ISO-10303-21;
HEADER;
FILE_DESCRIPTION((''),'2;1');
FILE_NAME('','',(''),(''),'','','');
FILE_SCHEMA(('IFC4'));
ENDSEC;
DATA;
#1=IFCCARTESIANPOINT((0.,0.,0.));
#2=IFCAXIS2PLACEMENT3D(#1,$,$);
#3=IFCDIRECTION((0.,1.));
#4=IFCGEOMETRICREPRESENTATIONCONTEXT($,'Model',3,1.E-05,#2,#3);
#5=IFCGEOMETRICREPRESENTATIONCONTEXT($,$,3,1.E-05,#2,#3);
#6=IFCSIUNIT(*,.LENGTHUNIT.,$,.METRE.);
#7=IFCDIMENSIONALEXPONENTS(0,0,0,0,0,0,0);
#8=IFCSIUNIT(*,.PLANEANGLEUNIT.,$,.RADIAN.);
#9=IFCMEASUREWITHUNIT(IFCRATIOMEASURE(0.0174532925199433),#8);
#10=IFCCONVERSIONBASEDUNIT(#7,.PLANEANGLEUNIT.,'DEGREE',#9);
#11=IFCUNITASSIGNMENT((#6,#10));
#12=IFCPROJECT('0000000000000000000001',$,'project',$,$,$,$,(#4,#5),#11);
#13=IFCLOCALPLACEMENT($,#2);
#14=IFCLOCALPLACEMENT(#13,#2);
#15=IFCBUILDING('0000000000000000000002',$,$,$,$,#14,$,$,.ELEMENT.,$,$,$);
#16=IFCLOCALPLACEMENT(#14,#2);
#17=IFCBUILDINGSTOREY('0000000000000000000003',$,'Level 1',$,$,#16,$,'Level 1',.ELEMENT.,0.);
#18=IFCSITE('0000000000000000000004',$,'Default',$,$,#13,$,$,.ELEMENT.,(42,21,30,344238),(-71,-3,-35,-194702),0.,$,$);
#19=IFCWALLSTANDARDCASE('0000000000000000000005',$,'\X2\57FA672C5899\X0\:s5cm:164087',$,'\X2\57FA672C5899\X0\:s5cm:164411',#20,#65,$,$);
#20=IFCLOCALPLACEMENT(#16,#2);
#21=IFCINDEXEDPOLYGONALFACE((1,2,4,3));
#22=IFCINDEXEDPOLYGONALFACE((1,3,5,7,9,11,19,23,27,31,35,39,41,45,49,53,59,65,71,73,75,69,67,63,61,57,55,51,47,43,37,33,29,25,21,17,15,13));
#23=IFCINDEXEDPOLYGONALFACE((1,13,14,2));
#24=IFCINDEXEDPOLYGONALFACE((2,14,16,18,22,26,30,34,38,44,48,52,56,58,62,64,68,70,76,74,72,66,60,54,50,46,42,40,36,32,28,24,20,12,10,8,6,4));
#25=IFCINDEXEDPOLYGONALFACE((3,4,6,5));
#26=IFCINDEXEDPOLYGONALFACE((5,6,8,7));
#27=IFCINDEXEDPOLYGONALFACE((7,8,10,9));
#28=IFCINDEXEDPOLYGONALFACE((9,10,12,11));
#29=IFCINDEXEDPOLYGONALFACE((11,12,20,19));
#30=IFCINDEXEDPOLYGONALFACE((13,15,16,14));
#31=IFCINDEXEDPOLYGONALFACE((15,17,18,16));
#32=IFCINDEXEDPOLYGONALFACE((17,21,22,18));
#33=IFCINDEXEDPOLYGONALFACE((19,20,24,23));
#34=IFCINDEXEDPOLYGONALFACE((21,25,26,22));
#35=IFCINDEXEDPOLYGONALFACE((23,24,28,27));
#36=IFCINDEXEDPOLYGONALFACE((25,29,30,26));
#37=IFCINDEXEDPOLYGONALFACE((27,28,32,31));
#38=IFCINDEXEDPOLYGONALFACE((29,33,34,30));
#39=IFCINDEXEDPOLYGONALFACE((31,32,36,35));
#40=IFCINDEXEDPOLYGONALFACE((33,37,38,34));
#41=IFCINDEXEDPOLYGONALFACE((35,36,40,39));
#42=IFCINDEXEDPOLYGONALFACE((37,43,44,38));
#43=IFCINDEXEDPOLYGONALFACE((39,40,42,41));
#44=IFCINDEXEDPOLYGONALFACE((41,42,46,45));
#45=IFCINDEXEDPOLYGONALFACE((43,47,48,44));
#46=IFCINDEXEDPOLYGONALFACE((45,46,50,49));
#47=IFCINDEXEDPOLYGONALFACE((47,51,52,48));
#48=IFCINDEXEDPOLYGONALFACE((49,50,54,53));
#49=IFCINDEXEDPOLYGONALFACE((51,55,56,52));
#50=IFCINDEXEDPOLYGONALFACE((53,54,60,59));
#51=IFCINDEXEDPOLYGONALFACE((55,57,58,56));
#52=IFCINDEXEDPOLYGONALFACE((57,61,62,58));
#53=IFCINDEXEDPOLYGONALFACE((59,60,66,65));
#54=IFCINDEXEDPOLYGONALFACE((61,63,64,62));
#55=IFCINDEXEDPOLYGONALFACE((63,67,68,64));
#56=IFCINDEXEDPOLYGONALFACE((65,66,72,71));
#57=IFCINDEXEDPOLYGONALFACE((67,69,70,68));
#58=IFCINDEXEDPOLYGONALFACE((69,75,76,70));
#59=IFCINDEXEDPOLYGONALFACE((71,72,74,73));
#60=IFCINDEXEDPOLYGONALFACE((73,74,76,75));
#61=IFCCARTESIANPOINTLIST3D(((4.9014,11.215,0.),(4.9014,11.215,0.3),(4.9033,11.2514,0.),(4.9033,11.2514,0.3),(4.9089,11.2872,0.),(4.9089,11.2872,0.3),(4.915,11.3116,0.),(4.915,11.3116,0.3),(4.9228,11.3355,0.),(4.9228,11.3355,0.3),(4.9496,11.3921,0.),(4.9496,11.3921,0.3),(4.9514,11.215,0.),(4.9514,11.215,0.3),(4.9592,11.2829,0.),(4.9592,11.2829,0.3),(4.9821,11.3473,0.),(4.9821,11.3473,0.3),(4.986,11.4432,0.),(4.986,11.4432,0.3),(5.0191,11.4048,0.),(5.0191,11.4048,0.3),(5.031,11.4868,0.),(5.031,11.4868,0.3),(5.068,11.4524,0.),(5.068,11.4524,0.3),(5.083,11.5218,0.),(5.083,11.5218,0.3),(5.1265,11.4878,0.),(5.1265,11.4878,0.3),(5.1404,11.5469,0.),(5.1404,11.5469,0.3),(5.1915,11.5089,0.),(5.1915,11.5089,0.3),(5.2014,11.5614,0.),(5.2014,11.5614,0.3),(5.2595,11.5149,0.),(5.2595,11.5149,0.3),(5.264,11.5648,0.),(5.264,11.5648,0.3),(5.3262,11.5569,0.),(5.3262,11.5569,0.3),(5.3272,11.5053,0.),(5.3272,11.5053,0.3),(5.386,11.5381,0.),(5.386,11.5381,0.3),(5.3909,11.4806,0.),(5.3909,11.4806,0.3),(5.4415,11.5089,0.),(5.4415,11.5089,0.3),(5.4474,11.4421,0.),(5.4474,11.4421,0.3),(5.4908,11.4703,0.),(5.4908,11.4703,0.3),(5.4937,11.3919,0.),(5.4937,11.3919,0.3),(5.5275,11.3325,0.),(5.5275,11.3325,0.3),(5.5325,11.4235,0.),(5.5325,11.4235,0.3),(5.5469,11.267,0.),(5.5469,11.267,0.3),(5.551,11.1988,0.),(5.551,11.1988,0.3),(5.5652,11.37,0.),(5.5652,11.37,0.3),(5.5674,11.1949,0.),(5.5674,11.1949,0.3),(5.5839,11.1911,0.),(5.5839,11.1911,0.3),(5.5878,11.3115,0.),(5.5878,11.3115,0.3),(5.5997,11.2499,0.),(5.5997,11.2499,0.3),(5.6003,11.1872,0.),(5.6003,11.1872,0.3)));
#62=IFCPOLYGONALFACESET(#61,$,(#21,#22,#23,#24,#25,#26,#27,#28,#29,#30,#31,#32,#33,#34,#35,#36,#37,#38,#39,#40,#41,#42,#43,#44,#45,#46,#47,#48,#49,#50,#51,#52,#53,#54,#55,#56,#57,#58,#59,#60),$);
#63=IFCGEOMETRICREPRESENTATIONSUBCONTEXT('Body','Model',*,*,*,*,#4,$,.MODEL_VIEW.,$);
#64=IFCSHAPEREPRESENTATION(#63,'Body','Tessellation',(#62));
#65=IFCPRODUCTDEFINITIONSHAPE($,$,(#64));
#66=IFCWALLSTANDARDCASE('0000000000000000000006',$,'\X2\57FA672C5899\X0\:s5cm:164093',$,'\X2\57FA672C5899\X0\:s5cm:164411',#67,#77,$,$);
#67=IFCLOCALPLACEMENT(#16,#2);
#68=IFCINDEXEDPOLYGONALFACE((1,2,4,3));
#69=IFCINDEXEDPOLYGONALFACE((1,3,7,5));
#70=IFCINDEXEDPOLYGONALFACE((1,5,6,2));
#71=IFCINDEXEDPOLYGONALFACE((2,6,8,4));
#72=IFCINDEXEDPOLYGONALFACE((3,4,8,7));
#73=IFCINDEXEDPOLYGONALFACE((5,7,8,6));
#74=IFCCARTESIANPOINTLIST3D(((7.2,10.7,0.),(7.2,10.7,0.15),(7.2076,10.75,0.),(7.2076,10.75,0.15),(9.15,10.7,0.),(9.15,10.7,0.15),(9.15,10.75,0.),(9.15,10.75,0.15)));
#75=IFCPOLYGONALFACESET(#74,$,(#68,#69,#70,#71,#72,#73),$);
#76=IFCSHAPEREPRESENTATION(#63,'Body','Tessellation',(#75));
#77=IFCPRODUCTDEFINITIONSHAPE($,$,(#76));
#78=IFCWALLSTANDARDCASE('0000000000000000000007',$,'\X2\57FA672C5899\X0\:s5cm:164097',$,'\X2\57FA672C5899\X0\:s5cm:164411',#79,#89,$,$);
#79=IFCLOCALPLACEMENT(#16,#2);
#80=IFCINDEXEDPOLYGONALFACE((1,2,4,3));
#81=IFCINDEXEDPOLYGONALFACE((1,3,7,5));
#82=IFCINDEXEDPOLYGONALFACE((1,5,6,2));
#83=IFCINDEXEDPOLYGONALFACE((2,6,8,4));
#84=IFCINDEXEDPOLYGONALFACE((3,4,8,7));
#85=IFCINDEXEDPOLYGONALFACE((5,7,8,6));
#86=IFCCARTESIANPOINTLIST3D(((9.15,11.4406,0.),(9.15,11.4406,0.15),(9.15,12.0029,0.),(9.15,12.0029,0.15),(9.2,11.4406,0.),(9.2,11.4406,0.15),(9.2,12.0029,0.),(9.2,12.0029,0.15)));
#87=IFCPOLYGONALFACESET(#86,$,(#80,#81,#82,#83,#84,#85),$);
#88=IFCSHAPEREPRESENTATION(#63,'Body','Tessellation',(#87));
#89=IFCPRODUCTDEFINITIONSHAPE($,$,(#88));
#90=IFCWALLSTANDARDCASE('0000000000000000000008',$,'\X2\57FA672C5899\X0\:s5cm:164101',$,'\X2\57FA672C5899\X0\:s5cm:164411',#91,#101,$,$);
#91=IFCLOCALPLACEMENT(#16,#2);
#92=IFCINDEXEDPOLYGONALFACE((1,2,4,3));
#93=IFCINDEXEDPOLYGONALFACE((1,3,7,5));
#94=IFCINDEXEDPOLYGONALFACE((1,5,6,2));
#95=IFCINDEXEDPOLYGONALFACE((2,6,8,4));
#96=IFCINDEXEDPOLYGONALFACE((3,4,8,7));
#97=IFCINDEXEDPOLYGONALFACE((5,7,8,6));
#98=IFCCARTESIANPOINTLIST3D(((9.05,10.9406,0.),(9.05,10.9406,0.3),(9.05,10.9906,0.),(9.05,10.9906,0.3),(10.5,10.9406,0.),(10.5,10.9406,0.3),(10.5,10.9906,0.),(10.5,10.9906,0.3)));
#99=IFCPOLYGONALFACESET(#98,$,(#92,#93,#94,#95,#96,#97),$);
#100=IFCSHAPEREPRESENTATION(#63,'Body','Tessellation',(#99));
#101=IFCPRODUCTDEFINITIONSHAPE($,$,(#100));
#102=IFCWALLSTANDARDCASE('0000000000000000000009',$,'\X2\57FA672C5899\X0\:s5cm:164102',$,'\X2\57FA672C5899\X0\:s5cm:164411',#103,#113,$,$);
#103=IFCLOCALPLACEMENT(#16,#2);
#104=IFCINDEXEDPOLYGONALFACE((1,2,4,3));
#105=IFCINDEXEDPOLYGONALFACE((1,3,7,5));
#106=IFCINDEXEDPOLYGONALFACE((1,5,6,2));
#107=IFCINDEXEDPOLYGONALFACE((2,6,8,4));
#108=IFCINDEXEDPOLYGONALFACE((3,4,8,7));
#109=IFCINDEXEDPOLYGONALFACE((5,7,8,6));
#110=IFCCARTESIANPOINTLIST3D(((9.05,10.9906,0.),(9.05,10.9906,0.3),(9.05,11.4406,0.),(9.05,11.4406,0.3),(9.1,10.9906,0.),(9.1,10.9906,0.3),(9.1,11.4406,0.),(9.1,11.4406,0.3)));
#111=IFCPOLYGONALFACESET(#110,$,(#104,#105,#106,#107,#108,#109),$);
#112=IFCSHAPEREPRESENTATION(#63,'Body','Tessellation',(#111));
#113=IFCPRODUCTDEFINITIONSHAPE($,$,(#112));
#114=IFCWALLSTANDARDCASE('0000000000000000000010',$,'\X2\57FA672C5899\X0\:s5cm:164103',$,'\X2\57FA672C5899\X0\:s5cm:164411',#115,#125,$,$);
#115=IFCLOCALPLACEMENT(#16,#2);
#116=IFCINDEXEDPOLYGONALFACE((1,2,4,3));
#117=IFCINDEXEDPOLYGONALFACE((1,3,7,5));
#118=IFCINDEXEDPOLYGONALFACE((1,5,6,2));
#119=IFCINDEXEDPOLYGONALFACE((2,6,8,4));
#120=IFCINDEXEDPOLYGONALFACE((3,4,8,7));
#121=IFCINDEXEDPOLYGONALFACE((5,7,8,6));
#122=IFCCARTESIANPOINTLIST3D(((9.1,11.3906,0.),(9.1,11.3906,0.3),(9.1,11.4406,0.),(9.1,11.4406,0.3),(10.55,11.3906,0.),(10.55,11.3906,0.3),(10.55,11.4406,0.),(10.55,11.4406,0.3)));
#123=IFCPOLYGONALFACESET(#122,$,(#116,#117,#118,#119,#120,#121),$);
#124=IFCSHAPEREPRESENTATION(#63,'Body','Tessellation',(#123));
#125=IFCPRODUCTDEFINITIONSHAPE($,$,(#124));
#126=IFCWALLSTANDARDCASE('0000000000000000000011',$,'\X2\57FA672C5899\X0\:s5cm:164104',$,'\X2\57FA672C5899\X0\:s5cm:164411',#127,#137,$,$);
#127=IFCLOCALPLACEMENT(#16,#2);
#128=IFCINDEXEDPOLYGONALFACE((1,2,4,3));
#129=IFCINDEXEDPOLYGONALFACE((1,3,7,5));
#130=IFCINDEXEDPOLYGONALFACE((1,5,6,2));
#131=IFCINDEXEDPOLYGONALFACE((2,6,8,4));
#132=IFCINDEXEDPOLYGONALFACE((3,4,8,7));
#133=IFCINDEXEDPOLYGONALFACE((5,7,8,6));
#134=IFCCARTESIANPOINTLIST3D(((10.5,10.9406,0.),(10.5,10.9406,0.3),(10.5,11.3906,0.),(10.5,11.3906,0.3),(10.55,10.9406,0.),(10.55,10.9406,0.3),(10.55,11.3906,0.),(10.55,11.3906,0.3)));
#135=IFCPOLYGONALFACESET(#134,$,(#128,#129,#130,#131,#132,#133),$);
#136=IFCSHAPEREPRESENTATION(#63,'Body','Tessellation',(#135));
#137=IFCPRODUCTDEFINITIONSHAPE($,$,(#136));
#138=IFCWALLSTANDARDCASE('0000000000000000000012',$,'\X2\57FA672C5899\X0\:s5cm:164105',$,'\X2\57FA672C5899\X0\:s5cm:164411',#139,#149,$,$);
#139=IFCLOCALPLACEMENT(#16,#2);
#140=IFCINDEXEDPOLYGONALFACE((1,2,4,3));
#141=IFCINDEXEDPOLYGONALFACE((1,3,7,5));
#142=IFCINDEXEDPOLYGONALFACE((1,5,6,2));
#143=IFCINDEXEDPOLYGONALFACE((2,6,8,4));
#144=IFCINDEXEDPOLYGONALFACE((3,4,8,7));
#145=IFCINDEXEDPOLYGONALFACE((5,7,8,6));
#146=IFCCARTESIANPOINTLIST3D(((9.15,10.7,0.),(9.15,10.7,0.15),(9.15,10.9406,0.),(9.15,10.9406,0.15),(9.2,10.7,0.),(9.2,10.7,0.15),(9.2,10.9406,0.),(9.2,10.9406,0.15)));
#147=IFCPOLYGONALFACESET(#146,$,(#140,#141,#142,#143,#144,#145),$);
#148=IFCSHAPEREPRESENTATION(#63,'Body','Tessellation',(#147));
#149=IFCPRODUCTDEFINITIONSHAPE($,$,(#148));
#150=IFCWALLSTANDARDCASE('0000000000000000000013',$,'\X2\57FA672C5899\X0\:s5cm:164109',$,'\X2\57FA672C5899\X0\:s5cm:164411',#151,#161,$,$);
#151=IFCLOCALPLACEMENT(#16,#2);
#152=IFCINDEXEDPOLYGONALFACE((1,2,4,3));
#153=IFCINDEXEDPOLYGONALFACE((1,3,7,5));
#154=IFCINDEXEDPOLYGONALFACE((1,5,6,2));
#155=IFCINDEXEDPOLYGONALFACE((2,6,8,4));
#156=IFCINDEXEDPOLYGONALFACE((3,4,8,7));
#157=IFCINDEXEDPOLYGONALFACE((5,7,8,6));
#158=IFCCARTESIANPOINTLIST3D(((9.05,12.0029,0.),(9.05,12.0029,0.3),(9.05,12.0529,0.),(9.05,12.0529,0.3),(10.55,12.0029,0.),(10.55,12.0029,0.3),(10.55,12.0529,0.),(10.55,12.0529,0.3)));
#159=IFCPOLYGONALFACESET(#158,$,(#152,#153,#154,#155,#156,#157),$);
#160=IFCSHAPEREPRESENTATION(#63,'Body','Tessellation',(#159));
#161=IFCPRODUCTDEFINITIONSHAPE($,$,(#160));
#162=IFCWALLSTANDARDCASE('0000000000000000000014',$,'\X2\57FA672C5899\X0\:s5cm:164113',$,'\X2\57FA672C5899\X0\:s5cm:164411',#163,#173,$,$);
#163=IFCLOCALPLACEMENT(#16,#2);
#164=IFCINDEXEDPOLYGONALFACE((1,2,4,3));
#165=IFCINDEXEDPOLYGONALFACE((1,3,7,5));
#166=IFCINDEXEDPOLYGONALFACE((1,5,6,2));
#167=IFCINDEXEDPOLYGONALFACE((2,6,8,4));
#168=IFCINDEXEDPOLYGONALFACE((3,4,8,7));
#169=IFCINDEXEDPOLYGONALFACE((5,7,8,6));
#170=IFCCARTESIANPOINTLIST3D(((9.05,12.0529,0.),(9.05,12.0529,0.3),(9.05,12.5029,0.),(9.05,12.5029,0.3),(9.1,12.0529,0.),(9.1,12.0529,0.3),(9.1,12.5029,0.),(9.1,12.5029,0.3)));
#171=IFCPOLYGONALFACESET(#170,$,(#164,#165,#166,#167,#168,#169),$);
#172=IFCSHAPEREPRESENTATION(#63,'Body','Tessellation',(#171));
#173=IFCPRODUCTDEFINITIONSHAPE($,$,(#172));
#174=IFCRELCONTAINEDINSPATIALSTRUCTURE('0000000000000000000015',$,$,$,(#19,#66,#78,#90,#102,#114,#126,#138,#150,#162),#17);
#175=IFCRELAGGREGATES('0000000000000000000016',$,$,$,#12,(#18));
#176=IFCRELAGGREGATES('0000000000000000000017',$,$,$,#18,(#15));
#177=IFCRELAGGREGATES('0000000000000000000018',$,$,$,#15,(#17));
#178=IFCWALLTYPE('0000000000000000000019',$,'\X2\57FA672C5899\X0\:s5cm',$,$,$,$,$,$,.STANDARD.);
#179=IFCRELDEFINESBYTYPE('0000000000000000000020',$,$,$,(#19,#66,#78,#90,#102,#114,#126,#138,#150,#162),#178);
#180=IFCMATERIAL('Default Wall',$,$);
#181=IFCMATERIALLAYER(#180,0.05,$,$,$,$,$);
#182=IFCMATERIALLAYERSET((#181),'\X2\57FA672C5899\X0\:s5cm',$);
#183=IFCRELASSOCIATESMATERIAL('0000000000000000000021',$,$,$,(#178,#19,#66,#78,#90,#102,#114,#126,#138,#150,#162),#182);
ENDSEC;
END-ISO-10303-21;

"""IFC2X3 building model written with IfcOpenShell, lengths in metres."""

from ifc_helpers import new_model, entity, si_unit, converted_unit, direction, frame, frame_2d, origin, place, context, subcontext, project, spatial, polyline, circle_curve, parameter, trimmed, segment, composite_curve, rectangle, outline, extrude, material, layer, layer_set, layer_usage, type_object, element, save


model = new_model("IFC2X3")

# Units and contexts
model_context = context("Model", 3, precision=1e-05, world=origin(), true_north=direction((0.0, 1.0)))
context_of_model = context(None, 3, precision=1e-05, world=origin(), true_north=direction((0.0, 1.0)))
body_context = subcontext(model_context, "Body", "Model", "MODEL_VIEW")
ifc_project = project(units=[si_unit("LENGTHUNIT", "METRE"), converted_unit("PLANEANGLEUNIT", "DEGREE", entity("IfcRatioMeasure", 0.0174532925199433), si_unit("PLANEANGLEUNIT", "RADIAN"), dimensions=[0, 0, 0, 0, 0, 0, 0])], contexts=[model_context, context_of_model])

# Site, building, storey
site_placement = place(None, origin())
site = spatial("IfcSite", under=ifc_project, at=site_placement, Name="Default", CompositionType="ELEMENT", RefLatitude=(42, 21, 30, 344238), RefLongitude=(-71, -3, -35, -194702), RefElevation=0.0)
building_placement = place(site_placement, origin())
building = spatial("IfcBuilding", under=site, at=building_placement, CompositionType="ELEMENT")
storey_placement = place(building_placement, origin())
storey = spatial("IfcBuildingStorey", under=building, at=storey_placement, Name="Level 1", LongName="Level 1", CompositionType="ELEMENT", Elevation=0.0)

# Walls
ifc_material = material(Name="Default Wall")
ifc_layer = layer(ifc_material, 0.05)
ifc_layer_set = layer_set([ifc_layer], Name="基本墙:s5cm")
wall_type = type_object("IfcWallType", Name="基本墙:s5cm", PredefinedType="STANDARD", material=ifc_layer_set)
ifc_layer_usage_1 = layer_usage(ifc_layer_set, "AXIS2", "POSITIVE", -0.025)
wall_1_placement = place(storey_placement, frame((4.9264, 11.215, 0.0)))
element("IfcWallStandardCase", 1, at=wall_1_placement, inside=storey, type_object=wall_type, material=ifc_layer_usage_1, Name="基本墙:s5cm:164087", ObjectType="基本墙:s5cm:164411", context=body_context, shape_type="SweptSolid", body=[
    extrude(outline(composite_curve([segment(polyline([(0.6739, -0.0278), (0.6733, 0.0349)]), True, "CONTINUOUS"), segment(polyline([(0.6733, 0.0349), (0.6614, 0.0965)]), True, "CONTINUOUS"), segment(polyline([(0.6614, 0.0965), (0.6388, 0.155)]), True, "CONTINUOUS"), segment(polyline([(0.6388, 0.155), (0.6061, 0.2085)]), True, "CONTINUOUS"), segment(polyline([(0.6061, 0.2085), (0.5644, 0.2553)]), True, "CONTINUOUS"), segment(polyline([(0.5644, 0.2553), (0.515, 0.2939)]), True, "CONTINUOUS"), segment(polyline([(0.515, 0.2939), (0.4596, 0.3231)]), True, "CONTINUOUS"), segment(polyline([(0.4596, 0.3231), (0.3998, 0.3419)]), True, "CONTINUOUS"), segment(polyline([(0.3998, 0.3419), (0.3376, 0.3498)]), True, "CONTINUOUS"), segment(polyline([(0.3376, 0.3498), (0.275, 0.3464)]), True, "CONTINUOUS"), segment(polyline([(0.275, 0.3464), (0.214, 0.3319)]), True, "CONTINUOUS"), segment(polyline([(0.214, 0.3319), (0.1566, 0.3068)]), True, "CONTINUOUS"), segment(polyline([(0.1566, 0.3068), (0.1045, 0.2718)]), True, "CONTINUOUS"), segment(polyline([(0.1045, 0.2718), (0.0596, 0.2282)]), True, "CONTINUOUS"), segment(polyline([(0.0596, 0.2282), (0.0231, 0.1771)]), True, "CONTINUOUS"), segment(polyline([(0.0231, 0.1771), (-0.0036, 0.1205)]), True, "CONTINUOUS"), segment(polyline([(-0.0036, 0.1205), (-0.0114, 0.0966)]), True, "CONTINUOUS"), segment(polyline([(-0.0114, 0.0966), (-0.0175, 0.0722)]), True, "CONTINUOUS"), segment(polyline([(-0.0175, 0.0722), (-0.0231, 0.0364)]), True, "CONTINUOUS"), segment(polyline([(-0.0231, 0.0364), (-0.025, 0.0)]), True, "CONTINUOUS"), segment(polyline([(-0.025, 0.0), (0.025, 0.0)]), True, "CONTINUOUS"), segment(trimmed(circle_curve(frame_2d((0.325, 0.0), x_axis=(1.0, 0.0)), 0.3), [parameter(356.895175)], [parameter(180.0)], True, "PARAMETER"), False, "CONTINUOUS"), segment(trimmed(circle_curve(frame_2d((-4.6764, -22.8675), x_axis=(1.0, 0.0)), 23.458), [parameter(76.815925)], [parameter(76.939664)], True, "PARAMETER"), False, "CONTINUOUS")], self_intersect=False)), origin(), (0.0, 0.0, 1.0), 0.3),
])
ifc_layer_usage_2 = layer_usage(ifc_layer_set, "AXIS2", "NEGATIVE", 0.025)
wall_2_placement = place(storey_placement, frame((9.15, 10.725, 0.0), z_axis=(0.0, 0.0, 1.0), x_axis=(-1.0, 0.0, 0.0)))
element("IfcWallStandardCase", 2, at=wall_2_placement, inside=storey, type_object=wall_type, material=ifc_layer_usage_2, Name="基本墙:s5cm:164093", ObjectType="基本墙:s5cm:164411", context=body_context, shape_type="SweptSolid", body=[
    extrude(outline(polyline([(1.9424, -0.025), (1.95, 0.025), (0.0, 0.025), (0.0, -0.025), (1.9424, -0.025)])), origin(), (0.0, 0.0, 1.0), 0.15),
])
ifc_layer_usage_3 = layer_usage(ifc_layer_set, "AXIS2", "NEGATIVE", 0.025)
wall_3_placement = place(storey_placement, frame((9.175, 12.0029, 0.0), z_axis=(0.0, 0.0, 1.0), x_axis=(0.0, -1.0, 0.0)))
element("IfcWallStandardCase", 3, at=wall_3_placement, inside=storey, type_object=wall_type, material=ifc_layer_usage_3, Name="基本墙:s5cm:164097", ObjectType="基本墙:s5cm:164411", context=body_context, shape_type="SweptSolid", body=[
    extrude(rectangle(XDim=0.5623, YDim=0.05, at=frame_2d((0.2811, 0.0), x_axis=(-1.0, 0.0))), origin(), (0.0, 0.0, 1.0), 0.15),
])
ifc_layer_usage_4 = layer_usage(ifc_layer_set, "AXIS2", "NEGATIVE", 0.025)
wall_4_placement = place(storey_placement, frame((10.5, 10.9656, 0.0), z_axis=(0.0, 0.0, 1.0), x_axis=(-1.0, 0.0, 0.0)))
element("IfcWallStandardCase", 4, at=wall_4_placement, inside=storey, type_object=wall_type, material=ifc_layer_usage_4, Name="基本墙:s5cm:164101", ObjectType="基本墙:s5cm:164411", context=body_context, shape_type="SweptSolid", body=[
    extrude(rectangle(XDim=1.45, YDim=0.05, at=frame_2d((0.725, 0.0), x_axis=(-1.0, 0.0))), origin(), (0.0, 0.0, 1.0), 0.3),
])
ifc_layer_usage_5 = layer_usage(ifc_layer_set, "AXIS2", "NEGATIVE", 0.025)
wall_5_placement = place(storey_placement, frame((9.075, 10.9906, 0.0), z_axis=(0.0, 0.0, 1.0), x_axis=(0.0, 1.0, 0.0)))
element("IfcWallStandardCase", 5, at=wall_5_placement, inside=storey, type_object=wall_type, material=ifc_layer_usage_5, Name="基本墙:s5cm:164102", ObjectType="基本墙:s5cm:164411", context=body_context, shape_type="SweptSolid", body=[
    extrude(rectangle(XDim=0.45, YDim=0.05, at=frame_2d((0.225, 0.0), x_axis=(-1.0, 0.0))), origin(), (0.0, 0.0, 1.0), 0.3),
])
ifc_layer_usage_6 = layer_usage(ifc_layer_set, "AXIS2", "NEGATIVE", 0.025)
wall_6_placement = place(storey_placement, frame((9.1, 11.4156, 0.0)))
element("IfcWallStandardCase", 6, at=wall_6_placement, inside=storey, type_object=wall_type, material=ifc_layer_usage_6, Name="基本墙:s5cm:164103", ObjectType="基本墙:s5cm:164411", context=body_context, shape_type="SweptSolid", body=[
    extrude(rectangle(XDim=1.45, YDim=0.05, at=frame_2d((0.725, 0.0), x_axis=(-1.0, 0.0))), origin(), (0.0, 0.0, 1.0), 0.3),
])
ifc_layer_usage_7 = layer_usage(ifc_layer_set, "AXIS2", "NEGATIVE", 0.025)
wall_7_placement = place(storey_placement, frame((10.525, 11.3906, 0.0), z_axis=(0.0, 0.0, 1.0), x_axis=(0.0, -1.0, 0.0)))
element("IfcWallStandardCase", 7, at=wall_7_placement, inside=storey, type_object=wall_type, material=ifc_layer_usage_7, Name="基本墙:s5cm:164104", ObjectType="基本墙:s5cm:164411", context=body_context, shape_type="SweptSolid", body=[
    extrude(rectangle(XDim=0.45, YDim=0.05, at=frame_2d((0.225, 0.0), x_axis=(-1.0, 0.0))), origin(), (0.0, 0.0, 1.0), 0.3),
])
ifc_layer_usage_8 = layer_usage(ifc_layer_set, "AXIS2", "NEGATIVE", 0.025)
wall_8_placement = place(storey_placement, frame((9.175, 10.9406, 0.0), z_axis=(0.0, 0.0, 1.0), x_axis=(0.0, -1.0, 0.0)))
element("IfcWallStandardCase", 8, at=wall_8_placement, inside=storey, type_object=wall_type, material=ifc_layer_usage_8, Name="基本墙:s5cm:164105", ObjectType="基本墙:s5cm:164411", context=body_context, shape_type="SweptSolid", body=[
    extrude(rectangle(XDim=0.2406, YDim=0.05, at=frame_2d((0.1203, 0.0), x_axis=(-1.0, 0.0))), origin(), (0.0, 0.0, 1.0), 0.15),
])
ifc_layer_usage_9 = layer_usage(ifc_layer_set, "AXIS2", "NEGATIVE", 0.025)
wall_9_placement = place(storey_placement, frame((10.55, 12.0279, 0.0), z_axis=(0.0, 0.0, 1.0), x_axis=(-1.0, 0.0, 0.0)))
element("IfcWallStandardCase", 9, at=wall_9_placement, inside=storey, type_object=wall_type, material=ifc_layer_usage_9, Name="基本墙:s5cm:164109", ObjectType="基本墙:s5cm:164411", context=body_context, shape_type="SweptSolid", body=[
    extrude(rectangle(XDim=1.5, YDim=0.05, at=frame_2d((0.75, 0.0), x_axis=(-1.0, 0.0))), origin(), (0.0, 0.0, 1.0), 0.3),
])
ifc_layer_usage_10 = layer_usage(ifc_layer_set, "AXIS2", "NEGATIVE", 0.025)
wall_10_placement = place(storey_placement, frame((9.075, 12.0529, 0.0), z_axis=(0.0, 0.0, 1.0), x_axis=(0.0, 1.0, 0.0)))
element("IfcWallStandardCase", 10, at=wall_10_placement, inside=storey, type_object=wall_type, material=ifc_layer_usage_10, Name="基本墙:s5cm:164113", ObjectType="基本墙:s5cm:164411", context=body_context, shape_type="SweptSolid", body=[
    extrude(rectangle(XDim=0.45, YDim=0.05, at=frame_2d((0.225, 0.0), x_axis=(-1.0, 0.0))), origin(), (0.0, 0.0, 1.0), 0.3),
])

save(model, "model.ifc")
